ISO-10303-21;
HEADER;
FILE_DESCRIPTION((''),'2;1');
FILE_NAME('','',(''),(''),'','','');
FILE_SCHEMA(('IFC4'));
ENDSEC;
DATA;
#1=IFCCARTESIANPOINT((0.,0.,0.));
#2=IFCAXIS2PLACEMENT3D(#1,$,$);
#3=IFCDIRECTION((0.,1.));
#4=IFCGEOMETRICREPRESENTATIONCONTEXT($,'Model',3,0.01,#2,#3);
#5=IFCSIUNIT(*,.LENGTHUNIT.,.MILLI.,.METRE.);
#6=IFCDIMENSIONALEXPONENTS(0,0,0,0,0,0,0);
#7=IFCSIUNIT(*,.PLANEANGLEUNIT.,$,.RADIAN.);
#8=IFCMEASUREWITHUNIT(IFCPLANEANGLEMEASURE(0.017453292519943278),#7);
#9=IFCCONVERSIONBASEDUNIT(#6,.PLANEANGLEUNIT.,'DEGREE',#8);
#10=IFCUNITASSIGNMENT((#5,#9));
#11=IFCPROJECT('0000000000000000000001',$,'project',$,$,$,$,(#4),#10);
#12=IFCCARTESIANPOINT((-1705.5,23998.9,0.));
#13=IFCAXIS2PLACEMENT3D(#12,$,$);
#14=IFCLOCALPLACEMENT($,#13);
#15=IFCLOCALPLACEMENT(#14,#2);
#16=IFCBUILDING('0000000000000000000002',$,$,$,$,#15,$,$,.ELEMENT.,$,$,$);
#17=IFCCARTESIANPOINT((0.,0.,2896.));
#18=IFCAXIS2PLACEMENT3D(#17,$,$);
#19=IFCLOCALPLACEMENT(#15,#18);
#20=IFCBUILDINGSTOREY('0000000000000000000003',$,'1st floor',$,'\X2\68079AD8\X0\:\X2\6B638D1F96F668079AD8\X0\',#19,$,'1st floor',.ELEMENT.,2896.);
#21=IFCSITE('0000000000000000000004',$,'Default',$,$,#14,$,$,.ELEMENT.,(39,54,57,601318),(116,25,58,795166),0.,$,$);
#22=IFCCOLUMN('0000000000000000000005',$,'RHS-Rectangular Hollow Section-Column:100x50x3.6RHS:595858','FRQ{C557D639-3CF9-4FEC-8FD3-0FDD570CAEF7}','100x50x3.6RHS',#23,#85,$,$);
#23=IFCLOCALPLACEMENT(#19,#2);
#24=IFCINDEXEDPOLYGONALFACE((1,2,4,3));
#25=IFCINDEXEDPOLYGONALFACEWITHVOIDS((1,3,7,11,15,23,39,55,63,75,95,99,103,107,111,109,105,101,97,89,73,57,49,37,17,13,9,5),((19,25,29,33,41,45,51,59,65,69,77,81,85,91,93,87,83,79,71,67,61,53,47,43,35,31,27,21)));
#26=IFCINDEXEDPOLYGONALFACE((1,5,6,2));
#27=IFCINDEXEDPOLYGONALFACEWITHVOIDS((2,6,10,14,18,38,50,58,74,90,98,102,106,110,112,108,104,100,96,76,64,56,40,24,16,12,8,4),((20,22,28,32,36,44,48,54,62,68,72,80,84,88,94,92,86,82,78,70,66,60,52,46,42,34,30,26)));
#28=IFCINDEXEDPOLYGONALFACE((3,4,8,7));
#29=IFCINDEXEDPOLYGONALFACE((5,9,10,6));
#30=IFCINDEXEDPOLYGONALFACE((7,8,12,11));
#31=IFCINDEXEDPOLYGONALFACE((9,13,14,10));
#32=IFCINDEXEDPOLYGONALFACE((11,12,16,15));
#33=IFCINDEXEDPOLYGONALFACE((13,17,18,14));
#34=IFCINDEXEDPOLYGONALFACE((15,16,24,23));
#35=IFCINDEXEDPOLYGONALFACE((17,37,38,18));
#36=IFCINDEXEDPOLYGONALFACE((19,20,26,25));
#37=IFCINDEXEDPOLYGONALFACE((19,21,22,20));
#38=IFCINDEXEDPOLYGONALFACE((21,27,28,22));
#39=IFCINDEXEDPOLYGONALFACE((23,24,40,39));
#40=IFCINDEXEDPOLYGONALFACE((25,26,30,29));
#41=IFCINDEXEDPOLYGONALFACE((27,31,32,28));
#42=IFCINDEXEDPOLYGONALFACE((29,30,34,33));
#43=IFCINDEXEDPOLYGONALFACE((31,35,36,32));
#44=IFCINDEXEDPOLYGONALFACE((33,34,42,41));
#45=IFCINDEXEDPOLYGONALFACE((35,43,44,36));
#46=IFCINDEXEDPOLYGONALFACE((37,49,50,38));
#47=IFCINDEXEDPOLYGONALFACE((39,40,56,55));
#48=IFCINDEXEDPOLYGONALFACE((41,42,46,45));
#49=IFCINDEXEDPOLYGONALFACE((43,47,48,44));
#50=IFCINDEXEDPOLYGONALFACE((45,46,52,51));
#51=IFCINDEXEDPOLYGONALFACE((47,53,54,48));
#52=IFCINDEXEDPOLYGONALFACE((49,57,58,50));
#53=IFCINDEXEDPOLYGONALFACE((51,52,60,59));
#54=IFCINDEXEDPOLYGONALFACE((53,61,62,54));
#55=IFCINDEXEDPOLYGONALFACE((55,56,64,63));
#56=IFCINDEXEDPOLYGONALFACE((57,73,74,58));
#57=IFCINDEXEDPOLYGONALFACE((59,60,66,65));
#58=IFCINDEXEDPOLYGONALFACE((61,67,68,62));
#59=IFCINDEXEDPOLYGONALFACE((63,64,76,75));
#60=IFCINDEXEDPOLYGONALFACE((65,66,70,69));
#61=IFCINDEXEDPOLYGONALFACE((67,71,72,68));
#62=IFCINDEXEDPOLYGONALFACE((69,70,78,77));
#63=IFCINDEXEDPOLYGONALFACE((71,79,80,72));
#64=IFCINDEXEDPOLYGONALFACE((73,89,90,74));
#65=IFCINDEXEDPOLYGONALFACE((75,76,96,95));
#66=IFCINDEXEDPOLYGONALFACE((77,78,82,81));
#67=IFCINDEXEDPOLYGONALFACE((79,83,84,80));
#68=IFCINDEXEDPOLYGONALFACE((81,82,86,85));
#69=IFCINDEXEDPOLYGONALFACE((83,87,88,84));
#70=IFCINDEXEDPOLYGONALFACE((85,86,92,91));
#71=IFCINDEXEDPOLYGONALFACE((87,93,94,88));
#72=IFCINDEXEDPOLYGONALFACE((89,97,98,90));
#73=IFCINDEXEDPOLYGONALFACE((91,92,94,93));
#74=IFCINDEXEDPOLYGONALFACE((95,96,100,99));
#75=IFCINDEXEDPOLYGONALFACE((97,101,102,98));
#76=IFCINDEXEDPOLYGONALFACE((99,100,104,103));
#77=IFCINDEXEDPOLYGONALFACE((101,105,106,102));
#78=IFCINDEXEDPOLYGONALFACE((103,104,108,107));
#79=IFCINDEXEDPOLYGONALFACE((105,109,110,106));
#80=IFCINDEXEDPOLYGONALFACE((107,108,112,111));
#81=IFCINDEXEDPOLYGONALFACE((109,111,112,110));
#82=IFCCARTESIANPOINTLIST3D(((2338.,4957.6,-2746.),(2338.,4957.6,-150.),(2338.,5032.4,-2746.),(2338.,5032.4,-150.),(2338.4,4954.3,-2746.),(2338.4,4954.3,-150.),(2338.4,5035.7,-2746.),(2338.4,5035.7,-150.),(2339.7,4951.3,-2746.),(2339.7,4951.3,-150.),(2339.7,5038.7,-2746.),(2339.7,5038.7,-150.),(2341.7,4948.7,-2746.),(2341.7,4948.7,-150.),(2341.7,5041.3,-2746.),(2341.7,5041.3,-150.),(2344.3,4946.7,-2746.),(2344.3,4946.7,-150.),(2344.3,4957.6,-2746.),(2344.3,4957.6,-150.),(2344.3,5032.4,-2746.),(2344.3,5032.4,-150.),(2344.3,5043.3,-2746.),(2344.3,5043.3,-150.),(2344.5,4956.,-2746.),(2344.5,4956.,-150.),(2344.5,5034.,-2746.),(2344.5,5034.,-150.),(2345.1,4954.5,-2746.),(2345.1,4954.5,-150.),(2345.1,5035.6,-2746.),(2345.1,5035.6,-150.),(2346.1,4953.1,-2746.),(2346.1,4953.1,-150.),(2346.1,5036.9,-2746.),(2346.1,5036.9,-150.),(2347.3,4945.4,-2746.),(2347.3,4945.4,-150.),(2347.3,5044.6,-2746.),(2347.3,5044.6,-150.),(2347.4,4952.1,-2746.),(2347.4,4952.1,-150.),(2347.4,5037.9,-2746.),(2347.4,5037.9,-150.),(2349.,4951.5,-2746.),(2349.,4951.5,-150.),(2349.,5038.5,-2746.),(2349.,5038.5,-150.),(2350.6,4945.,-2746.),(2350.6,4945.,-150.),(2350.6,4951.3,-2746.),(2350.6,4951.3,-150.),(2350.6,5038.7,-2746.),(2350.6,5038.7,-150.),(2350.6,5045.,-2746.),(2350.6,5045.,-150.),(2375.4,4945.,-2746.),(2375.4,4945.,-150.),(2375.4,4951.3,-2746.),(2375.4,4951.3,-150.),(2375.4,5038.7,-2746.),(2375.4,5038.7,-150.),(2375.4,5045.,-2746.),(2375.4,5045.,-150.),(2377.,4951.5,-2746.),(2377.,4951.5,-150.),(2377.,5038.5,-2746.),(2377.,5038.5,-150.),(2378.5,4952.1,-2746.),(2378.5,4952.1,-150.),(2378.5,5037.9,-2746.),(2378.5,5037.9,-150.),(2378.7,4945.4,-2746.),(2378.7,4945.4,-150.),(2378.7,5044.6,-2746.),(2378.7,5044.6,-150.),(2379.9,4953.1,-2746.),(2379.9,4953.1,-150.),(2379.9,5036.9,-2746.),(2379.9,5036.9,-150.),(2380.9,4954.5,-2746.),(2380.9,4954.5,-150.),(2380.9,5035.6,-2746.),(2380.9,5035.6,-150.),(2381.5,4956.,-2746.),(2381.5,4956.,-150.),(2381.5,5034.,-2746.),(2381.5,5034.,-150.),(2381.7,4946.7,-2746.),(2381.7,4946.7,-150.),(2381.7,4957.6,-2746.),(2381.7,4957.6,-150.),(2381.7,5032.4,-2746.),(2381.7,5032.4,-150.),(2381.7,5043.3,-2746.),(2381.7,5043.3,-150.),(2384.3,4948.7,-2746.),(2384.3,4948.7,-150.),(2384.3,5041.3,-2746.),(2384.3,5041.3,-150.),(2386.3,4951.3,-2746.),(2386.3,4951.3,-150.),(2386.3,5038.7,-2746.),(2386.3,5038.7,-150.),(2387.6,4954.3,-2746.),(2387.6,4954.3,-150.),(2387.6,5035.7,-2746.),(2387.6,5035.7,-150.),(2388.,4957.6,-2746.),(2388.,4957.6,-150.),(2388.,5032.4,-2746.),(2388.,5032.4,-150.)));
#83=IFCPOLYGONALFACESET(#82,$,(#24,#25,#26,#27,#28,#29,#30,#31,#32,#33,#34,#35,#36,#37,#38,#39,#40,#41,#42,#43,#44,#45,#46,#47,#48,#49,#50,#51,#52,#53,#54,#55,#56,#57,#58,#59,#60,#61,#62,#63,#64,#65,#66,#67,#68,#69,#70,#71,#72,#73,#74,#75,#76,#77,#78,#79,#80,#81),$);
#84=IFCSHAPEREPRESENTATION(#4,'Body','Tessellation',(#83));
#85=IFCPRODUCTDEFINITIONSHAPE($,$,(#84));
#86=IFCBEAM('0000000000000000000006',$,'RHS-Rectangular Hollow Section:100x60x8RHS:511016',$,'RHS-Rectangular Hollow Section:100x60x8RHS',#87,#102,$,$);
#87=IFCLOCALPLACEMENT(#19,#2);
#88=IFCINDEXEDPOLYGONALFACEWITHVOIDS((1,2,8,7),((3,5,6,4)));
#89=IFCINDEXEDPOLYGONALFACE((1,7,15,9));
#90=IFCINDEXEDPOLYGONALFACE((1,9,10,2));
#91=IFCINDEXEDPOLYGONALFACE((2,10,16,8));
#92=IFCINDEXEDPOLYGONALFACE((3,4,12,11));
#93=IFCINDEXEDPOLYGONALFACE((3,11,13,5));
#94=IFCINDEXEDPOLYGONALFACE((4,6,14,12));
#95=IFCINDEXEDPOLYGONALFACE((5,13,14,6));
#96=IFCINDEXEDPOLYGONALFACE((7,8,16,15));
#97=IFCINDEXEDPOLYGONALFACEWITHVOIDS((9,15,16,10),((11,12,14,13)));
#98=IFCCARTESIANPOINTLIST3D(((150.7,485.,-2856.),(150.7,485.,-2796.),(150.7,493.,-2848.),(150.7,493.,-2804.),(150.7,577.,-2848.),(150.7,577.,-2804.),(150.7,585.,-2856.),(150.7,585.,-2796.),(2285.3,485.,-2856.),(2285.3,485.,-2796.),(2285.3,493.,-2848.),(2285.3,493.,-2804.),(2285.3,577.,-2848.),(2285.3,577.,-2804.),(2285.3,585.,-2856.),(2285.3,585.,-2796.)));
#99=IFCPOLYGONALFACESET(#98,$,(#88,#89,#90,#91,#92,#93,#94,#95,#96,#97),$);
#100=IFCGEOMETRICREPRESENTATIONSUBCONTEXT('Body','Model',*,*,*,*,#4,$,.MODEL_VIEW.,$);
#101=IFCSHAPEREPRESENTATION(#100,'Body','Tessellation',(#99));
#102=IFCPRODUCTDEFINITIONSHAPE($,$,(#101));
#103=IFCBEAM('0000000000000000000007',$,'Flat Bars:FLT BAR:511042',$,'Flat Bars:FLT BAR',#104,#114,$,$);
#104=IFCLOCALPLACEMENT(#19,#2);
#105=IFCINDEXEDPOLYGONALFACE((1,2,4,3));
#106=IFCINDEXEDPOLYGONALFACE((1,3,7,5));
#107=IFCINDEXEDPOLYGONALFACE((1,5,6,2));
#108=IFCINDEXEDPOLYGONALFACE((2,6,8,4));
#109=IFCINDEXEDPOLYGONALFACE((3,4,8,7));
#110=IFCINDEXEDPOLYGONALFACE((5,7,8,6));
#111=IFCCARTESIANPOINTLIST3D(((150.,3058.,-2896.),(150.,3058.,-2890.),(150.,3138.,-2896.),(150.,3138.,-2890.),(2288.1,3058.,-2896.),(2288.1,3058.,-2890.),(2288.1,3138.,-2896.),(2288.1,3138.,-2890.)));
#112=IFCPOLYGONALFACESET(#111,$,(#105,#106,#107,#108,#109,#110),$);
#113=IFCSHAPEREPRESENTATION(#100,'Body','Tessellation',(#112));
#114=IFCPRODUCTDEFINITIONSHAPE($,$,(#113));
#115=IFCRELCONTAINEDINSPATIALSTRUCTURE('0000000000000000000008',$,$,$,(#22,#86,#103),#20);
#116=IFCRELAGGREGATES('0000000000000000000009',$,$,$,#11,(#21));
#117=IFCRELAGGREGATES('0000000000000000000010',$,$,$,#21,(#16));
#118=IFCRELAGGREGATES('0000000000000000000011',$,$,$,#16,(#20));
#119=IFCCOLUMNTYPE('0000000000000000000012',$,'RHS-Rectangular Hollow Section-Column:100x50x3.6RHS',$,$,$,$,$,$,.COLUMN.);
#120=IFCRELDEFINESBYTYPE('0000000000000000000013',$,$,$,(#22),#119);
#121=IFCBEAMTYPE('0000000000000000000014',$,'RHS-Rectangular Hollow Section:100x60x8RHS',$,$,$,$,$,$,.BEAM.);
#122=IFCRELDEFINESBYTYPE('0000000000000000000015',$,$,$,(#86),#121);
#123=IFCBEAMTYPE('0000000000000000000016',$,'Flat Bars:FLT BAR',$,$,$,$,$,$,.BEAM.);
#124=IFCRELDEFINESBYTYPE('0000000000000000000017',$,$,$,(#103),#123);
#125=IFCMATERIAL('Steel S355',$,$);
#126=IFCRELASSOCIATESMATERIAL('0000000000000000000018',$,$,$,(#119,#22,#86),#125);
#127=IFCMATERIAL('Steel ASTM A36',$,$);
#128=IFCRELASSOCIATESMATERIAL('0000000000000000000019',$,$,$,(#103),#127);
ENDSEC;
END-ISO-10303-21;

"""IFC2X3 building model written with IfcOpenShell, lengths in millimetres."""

from ifc_helpers import new_model, entity, si_unit, converted_unit, direction, frame, frame_2d, origin, origin_2d, origin_2d_with_axis, place, context, subcontext, project, spatial, rectangle, hollow_rectangle, extrude, boolean, clip, halfspace, material, type_object, element, save


model = new_model("IFC2X3")

# Units and contexts
model_context = context("Model", 3, precision=0.01, world=origin(), true_north=direction((0.0, 1.0)))
body_context = subcontext(model_context, "Body", "Model", "MODEL_VIEW")
ifc_project = project(units=[si_unit("LENGTHUNIT", "METRE", prefix="MILLI"), converted_unit("PLANEANGLEUNIT", "DEGREE", entity("IfcPlaneAngleMeasure", 0.017453292519943278), si_unit("PLANEANGLEUNIT", "RADIAN"), dimensions=[0, 0, 0, 0, 0, 0, 0])], contexts=[model_context])

# Site, building, storey
site_placement = place(None, frame((-1705.5, 23998.9, 0.0)))
site = spatial("IfcSite", under=ifc_project, at=site_placement, Name="Default", CompositionType="ELEMENT", RefLatitude=(39, 54, 57, 601318), RefLongitude=(116, 25, 58, 795166), RefElevation=0.0)
building_placement = place(site_placement, origin())
building = spatial("IfcBuilding", under=site, at=building_placement, CompositionType="ELEMENT")
storey_placement = place(building_placement, frame((0.0, 0.0, 2896.0)))
storey = spatial("IfcBuildingStorey", under=building, at=storey_placement, Name="1st floor", ObjectType="标高:正负零标高", LongName="1st floor", CompositionType="ELEMENT", Elevation=2896.0)

# Shared definitions
ifc_material_1 = material(Name="Steel S355")

# Column
column_type_1 = type_object("IfcColumnType", Name="RHS-Rectangular Hollow Section-Column:100x50x3.6RHS", PredefinedType="COLUMN", material=ifc_material_1)
column_1_placement = place(storey_placement, frame((2363.0, 4995.0, -150.0), z_axis=(0.0, 0.0, 1.0), x_axis=(-1.0, 0.0, 0.0)))
element("IfcColumn", 1, at=column_1_placement, inside=storey, type_object=column_type_1, material=ifc_material_1, Name="RHS-Rectangular Hollow Section-Column:100x50x3.6RHS:595858", Description="FRQ{C557D639-3CF9-4FEC-8FD3-0FDD570CAEF7}", ObjectType="100x50x3.6RHS", context=model_context, shape_type="Clipping", body=[
    clip(extrude(hollow_rectangle(XDim=50.0, YDim=100.0, WallThickness=6.3, InnerFilletRadius=6.3, OuterFilletRadius=12.6, at=origin_2d()), origin(), (0.0, 0.0, -1.0), 2651.9), halfspace(frame((2363.0, 4995.0, -2596.0), z_axis=(0.0, 0.0, 1.0), x_axis=(-1.0, 0.0, 0.0)), True)),
])

# Beams
beam_type_1 = type_object("IfcBeamType", Name="RHS-Rectangular Hollow Section:100x60x8RHS", PredefinedType="BEAM")
beam_1_placement = place(storey_placement, frame((150.7, 585.0, -2826.0)))
element("IfcBeam", 2, at=beam_1_placement, inside=storey, type_object=beam_type_1, material=ifc_material_1, Name="RHS-Rectangular Hollow Section:100x60x8RHS:511016", ObjectType="RHS-Rectangular Hollow Section:100x60x8RHS", context=body_context, shape_type="SweptSolid", body=[
    boolean("DIFFERENCE", extrude(rectangle(XDim=60.0, YDim=100.0, at=frame_2d((0.0, 0.0), x_axis=(1.0, 0.0))), frame((0.0, -50.0, 0.0), z_axis=(1.0, 0.0, 0.0), x_axis=(0.0, 0.0, -1.0)), (0.0, 0.0, 1.0), 2134.6), extrude(rectangle(XDim=44.0, YDim=84.0, at=frame_2d((0.0, 0.0), x_axis=(0.0, 1.0))), frame((2134.6, -50.0, 0.0), z_axis=(-1.0, 0.0, 0.0), x_axis=(0.0, 1.0, 0.0)), (0.0, 0.0, 1.0), 2134.6)),
])
ifc_material_2 = material(Name="Steel ASTM A36")
beam_type_2 = type_object("IfcBeamType", Name="Flat Bars:FLT BAR", PredefinedType="BEAM")
beam_2_placement = place(storey_placement, frame((150.0, 3098.0, -2890.0)))
element("IfcBeam", 3, at=beam_2_placement, inside=storey, type_object=beam_type_2, material=ifc_material_2, Name="Flat Bars:FLT BAR:511042", ObjectType="Flat Bars:FLT BAR", context=body_context, shape_type="SweptSolid", body=[
    extrude(rectangle(XDim=6.0, YDim=80.0, at=origin_2d_with_axis()), frame((0.0, 0.0, -3.0), z_axis=(1.0, 0.0, 0.0), x_axis=(0.0, 0.0, -1.0)), (0.0, 0.0, 1.0), 2138.1),
])

save(model, "model.ifc")
